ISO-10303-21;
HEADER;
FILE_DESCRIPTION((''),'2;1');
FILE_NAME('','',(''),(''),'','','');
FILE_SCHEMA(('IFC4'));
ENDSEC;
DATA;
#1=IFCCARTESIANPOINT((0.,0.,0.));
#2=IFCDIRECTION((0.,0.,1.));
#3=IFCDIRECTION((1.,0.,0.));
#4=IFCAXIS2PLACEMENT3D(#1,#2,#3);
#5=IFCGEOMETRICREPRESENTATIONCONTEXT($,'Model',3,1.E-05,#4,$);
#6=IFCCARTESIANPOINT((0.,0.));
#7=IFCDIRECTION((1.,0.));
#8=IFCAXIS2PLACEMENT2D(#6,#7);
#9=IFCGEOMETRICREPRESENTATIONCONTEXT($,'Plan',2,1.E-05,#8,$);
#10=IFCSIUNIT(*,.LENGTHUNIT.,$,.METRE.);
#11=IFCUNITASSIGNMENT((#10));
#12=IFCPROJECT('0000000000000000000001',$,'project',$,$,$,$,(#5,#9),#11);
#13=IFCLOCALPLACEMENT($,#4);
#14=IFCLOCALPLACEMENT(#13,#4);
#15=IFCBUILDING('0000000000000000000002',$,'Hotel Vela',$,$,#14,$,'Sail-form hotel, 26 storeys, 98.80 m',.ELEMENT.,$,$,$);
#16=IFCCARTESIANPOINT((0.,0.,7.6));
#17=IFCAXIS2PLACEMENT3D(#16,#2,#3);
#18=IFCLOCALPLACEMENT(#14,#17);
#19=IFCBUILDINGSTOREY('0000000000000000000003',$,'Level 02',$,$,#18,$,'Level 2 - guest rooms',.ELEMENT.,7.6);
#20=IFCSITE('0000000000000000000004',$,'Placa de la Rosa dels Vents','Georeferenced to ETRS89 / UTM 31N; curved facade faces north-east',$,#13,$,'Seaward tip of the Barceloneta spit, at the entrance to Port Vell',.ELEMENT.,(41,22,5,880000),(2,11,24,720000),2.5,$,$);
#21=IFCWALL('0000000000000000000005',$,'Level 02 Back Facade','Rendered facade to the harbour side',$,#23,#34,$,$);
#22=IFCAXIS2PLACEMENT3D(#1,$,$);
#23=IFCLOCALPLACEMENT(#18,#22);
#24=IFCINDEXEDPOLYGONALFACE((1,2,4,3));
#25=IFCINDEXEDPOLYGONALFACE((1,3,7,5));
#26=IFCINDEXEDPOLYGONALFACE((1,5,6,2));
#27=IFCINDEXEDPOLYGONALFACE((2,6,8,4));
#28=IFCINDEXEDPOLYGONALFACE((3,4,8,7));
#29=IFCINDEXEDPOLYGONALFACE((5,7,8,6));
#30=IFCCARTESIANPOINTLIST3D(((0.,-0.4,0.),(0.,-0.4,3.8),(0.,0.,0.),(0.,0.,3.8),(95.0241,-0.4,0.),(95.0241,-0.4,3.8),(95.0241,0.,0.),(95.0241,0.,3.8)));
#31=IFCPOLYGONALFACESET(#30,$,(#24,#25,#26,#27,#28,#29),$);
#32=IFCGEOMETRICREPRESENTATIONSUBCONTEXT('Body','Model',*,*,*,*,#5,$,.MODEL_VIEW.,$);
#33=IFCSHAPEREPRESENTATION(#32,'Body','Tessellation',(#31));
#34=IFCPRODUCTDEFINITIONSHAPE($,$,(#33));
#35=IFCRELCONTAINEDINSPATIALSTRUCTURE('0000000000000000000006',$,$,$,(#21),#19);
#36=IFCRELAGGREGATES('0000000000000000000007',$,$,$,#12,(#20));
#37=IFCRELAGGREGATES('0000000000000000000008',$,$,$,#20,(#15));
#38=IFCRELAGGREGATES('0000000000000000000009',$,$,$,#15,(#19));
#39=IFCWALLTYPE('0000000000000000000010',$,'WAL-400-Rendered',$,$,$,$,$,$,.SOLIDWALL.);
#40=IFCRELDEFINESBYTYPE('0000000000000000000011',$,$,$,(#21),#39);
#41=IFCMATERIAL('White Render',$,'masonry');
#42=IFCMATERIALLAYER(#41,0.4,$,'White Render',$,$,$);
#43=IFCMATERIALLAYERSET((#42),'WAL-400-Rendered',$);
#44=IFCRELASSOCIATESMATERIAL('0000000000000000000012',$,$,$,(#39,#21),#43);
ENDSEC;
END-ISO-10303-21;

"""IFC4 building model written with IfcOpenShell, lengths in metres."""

from ifc_helpers import new_model, si_unit, frame, origin_with_axes, origin_2d_with_axis, place, context, subcontext, project, spatial, line, indexed_curve, outline, extrude, material, layer, layer_set, layer_usage, type_object, element, save


model = new_model("IFC4")

# Units and contexts
model_context = context("Model", 3, precision=1e-05, world=origin_with_axes())
plan_context = context("Plan", 2, precision=1e-05, world=origin_2d_with_axis())
body_context = subcontext(model_context, "Body", "Model", "MODEL_VIEW")
ifc_project = project(units=[si_unit("LENGTHUNIT", "METRE")], contexts=[model_context, plan_context])

# Site, building, storey
site_placement = place(None, origin_with_axes())
site = spatial("IfcSite", under=ifc_project, at=site_placement, Name="Placa de la Rosa dels Vents", Description="Georeferenced to ETRS89 / UTM 31N; curved facade faces north-east", LongName="Seaward tip of the Barceloneta spit, at the entrance to Port Vell", CompositionType="ELEMENT", RefLatitude=(41, 22, 5, 880000), RefLongitude=(2, 11, 24, 720000), RefElevation=2.5)
building_placement = place(site_placement, origin_with_axes())
building = spatial("IfcBuilding", under=site, at=building_placement, Name="Hotel Vela", LongName="Sail-form hotel, 26 storeys, 98.80 m", CompositionType="ELEMENT")
storey_placement = place(building_placement, frame((0.0, 0.0, 7.6), z_axis=(0.0, 0.0, 1.0), x_axis=(1.0, 0.0, 0.0)))
storey = spatial("IfcBuildingStorey", under=building, at=storey_placement, Name="Level 02", LongName="Level 2 - guest rooms", CompositionType="ELEMENT", Elevation=7.6)

# Wall
ifc_material_1 = material(Name="White Render", Category="masonry")
ifc_layer_1 = layer(ifc_material_1, 0.4, Name="White Render")
ifc_layer_set_1 = layer_set([ifc_layer_1], Name="WAL-400-Rendered")
ifc_layer_usage_1 = layer_usage(ifc_layer_set_1, "AXIS2", "POSITIVE", 0.0)
wall_type = type_object("IfcWallType", Name="WAL-400-Rendered", PredefinedType="SOLIDWALL", material=ifc_layer_set_1)
wall_placement = place(storey_placement, frame((0.0, -0.4, 0.0), z_axis=(0.0, 0.0, 1.0), x_axis=(1.0, 0.0, 0.0)))
element("IfcWall", 1, at=wall_placement, inside=storey, type_object=wall_type, material=ifc_layer_usage_1, Name="Level 02 Back Facade", Description="Rendered facade to the harbour side", context=body_context, shape_type="SweptSolid", body=[
    extrude(outline(indexed_curve([(0.0, 0.0), (95.0241, 0.0), (95.0241, 0.4), (0.0, 0.4)], segments=[line(1, 2, 3, 4, 1)])), origin_with_axes(), (0.0, 0.0, 1.0), 3.8),
])

save(model, "model.ifc")
